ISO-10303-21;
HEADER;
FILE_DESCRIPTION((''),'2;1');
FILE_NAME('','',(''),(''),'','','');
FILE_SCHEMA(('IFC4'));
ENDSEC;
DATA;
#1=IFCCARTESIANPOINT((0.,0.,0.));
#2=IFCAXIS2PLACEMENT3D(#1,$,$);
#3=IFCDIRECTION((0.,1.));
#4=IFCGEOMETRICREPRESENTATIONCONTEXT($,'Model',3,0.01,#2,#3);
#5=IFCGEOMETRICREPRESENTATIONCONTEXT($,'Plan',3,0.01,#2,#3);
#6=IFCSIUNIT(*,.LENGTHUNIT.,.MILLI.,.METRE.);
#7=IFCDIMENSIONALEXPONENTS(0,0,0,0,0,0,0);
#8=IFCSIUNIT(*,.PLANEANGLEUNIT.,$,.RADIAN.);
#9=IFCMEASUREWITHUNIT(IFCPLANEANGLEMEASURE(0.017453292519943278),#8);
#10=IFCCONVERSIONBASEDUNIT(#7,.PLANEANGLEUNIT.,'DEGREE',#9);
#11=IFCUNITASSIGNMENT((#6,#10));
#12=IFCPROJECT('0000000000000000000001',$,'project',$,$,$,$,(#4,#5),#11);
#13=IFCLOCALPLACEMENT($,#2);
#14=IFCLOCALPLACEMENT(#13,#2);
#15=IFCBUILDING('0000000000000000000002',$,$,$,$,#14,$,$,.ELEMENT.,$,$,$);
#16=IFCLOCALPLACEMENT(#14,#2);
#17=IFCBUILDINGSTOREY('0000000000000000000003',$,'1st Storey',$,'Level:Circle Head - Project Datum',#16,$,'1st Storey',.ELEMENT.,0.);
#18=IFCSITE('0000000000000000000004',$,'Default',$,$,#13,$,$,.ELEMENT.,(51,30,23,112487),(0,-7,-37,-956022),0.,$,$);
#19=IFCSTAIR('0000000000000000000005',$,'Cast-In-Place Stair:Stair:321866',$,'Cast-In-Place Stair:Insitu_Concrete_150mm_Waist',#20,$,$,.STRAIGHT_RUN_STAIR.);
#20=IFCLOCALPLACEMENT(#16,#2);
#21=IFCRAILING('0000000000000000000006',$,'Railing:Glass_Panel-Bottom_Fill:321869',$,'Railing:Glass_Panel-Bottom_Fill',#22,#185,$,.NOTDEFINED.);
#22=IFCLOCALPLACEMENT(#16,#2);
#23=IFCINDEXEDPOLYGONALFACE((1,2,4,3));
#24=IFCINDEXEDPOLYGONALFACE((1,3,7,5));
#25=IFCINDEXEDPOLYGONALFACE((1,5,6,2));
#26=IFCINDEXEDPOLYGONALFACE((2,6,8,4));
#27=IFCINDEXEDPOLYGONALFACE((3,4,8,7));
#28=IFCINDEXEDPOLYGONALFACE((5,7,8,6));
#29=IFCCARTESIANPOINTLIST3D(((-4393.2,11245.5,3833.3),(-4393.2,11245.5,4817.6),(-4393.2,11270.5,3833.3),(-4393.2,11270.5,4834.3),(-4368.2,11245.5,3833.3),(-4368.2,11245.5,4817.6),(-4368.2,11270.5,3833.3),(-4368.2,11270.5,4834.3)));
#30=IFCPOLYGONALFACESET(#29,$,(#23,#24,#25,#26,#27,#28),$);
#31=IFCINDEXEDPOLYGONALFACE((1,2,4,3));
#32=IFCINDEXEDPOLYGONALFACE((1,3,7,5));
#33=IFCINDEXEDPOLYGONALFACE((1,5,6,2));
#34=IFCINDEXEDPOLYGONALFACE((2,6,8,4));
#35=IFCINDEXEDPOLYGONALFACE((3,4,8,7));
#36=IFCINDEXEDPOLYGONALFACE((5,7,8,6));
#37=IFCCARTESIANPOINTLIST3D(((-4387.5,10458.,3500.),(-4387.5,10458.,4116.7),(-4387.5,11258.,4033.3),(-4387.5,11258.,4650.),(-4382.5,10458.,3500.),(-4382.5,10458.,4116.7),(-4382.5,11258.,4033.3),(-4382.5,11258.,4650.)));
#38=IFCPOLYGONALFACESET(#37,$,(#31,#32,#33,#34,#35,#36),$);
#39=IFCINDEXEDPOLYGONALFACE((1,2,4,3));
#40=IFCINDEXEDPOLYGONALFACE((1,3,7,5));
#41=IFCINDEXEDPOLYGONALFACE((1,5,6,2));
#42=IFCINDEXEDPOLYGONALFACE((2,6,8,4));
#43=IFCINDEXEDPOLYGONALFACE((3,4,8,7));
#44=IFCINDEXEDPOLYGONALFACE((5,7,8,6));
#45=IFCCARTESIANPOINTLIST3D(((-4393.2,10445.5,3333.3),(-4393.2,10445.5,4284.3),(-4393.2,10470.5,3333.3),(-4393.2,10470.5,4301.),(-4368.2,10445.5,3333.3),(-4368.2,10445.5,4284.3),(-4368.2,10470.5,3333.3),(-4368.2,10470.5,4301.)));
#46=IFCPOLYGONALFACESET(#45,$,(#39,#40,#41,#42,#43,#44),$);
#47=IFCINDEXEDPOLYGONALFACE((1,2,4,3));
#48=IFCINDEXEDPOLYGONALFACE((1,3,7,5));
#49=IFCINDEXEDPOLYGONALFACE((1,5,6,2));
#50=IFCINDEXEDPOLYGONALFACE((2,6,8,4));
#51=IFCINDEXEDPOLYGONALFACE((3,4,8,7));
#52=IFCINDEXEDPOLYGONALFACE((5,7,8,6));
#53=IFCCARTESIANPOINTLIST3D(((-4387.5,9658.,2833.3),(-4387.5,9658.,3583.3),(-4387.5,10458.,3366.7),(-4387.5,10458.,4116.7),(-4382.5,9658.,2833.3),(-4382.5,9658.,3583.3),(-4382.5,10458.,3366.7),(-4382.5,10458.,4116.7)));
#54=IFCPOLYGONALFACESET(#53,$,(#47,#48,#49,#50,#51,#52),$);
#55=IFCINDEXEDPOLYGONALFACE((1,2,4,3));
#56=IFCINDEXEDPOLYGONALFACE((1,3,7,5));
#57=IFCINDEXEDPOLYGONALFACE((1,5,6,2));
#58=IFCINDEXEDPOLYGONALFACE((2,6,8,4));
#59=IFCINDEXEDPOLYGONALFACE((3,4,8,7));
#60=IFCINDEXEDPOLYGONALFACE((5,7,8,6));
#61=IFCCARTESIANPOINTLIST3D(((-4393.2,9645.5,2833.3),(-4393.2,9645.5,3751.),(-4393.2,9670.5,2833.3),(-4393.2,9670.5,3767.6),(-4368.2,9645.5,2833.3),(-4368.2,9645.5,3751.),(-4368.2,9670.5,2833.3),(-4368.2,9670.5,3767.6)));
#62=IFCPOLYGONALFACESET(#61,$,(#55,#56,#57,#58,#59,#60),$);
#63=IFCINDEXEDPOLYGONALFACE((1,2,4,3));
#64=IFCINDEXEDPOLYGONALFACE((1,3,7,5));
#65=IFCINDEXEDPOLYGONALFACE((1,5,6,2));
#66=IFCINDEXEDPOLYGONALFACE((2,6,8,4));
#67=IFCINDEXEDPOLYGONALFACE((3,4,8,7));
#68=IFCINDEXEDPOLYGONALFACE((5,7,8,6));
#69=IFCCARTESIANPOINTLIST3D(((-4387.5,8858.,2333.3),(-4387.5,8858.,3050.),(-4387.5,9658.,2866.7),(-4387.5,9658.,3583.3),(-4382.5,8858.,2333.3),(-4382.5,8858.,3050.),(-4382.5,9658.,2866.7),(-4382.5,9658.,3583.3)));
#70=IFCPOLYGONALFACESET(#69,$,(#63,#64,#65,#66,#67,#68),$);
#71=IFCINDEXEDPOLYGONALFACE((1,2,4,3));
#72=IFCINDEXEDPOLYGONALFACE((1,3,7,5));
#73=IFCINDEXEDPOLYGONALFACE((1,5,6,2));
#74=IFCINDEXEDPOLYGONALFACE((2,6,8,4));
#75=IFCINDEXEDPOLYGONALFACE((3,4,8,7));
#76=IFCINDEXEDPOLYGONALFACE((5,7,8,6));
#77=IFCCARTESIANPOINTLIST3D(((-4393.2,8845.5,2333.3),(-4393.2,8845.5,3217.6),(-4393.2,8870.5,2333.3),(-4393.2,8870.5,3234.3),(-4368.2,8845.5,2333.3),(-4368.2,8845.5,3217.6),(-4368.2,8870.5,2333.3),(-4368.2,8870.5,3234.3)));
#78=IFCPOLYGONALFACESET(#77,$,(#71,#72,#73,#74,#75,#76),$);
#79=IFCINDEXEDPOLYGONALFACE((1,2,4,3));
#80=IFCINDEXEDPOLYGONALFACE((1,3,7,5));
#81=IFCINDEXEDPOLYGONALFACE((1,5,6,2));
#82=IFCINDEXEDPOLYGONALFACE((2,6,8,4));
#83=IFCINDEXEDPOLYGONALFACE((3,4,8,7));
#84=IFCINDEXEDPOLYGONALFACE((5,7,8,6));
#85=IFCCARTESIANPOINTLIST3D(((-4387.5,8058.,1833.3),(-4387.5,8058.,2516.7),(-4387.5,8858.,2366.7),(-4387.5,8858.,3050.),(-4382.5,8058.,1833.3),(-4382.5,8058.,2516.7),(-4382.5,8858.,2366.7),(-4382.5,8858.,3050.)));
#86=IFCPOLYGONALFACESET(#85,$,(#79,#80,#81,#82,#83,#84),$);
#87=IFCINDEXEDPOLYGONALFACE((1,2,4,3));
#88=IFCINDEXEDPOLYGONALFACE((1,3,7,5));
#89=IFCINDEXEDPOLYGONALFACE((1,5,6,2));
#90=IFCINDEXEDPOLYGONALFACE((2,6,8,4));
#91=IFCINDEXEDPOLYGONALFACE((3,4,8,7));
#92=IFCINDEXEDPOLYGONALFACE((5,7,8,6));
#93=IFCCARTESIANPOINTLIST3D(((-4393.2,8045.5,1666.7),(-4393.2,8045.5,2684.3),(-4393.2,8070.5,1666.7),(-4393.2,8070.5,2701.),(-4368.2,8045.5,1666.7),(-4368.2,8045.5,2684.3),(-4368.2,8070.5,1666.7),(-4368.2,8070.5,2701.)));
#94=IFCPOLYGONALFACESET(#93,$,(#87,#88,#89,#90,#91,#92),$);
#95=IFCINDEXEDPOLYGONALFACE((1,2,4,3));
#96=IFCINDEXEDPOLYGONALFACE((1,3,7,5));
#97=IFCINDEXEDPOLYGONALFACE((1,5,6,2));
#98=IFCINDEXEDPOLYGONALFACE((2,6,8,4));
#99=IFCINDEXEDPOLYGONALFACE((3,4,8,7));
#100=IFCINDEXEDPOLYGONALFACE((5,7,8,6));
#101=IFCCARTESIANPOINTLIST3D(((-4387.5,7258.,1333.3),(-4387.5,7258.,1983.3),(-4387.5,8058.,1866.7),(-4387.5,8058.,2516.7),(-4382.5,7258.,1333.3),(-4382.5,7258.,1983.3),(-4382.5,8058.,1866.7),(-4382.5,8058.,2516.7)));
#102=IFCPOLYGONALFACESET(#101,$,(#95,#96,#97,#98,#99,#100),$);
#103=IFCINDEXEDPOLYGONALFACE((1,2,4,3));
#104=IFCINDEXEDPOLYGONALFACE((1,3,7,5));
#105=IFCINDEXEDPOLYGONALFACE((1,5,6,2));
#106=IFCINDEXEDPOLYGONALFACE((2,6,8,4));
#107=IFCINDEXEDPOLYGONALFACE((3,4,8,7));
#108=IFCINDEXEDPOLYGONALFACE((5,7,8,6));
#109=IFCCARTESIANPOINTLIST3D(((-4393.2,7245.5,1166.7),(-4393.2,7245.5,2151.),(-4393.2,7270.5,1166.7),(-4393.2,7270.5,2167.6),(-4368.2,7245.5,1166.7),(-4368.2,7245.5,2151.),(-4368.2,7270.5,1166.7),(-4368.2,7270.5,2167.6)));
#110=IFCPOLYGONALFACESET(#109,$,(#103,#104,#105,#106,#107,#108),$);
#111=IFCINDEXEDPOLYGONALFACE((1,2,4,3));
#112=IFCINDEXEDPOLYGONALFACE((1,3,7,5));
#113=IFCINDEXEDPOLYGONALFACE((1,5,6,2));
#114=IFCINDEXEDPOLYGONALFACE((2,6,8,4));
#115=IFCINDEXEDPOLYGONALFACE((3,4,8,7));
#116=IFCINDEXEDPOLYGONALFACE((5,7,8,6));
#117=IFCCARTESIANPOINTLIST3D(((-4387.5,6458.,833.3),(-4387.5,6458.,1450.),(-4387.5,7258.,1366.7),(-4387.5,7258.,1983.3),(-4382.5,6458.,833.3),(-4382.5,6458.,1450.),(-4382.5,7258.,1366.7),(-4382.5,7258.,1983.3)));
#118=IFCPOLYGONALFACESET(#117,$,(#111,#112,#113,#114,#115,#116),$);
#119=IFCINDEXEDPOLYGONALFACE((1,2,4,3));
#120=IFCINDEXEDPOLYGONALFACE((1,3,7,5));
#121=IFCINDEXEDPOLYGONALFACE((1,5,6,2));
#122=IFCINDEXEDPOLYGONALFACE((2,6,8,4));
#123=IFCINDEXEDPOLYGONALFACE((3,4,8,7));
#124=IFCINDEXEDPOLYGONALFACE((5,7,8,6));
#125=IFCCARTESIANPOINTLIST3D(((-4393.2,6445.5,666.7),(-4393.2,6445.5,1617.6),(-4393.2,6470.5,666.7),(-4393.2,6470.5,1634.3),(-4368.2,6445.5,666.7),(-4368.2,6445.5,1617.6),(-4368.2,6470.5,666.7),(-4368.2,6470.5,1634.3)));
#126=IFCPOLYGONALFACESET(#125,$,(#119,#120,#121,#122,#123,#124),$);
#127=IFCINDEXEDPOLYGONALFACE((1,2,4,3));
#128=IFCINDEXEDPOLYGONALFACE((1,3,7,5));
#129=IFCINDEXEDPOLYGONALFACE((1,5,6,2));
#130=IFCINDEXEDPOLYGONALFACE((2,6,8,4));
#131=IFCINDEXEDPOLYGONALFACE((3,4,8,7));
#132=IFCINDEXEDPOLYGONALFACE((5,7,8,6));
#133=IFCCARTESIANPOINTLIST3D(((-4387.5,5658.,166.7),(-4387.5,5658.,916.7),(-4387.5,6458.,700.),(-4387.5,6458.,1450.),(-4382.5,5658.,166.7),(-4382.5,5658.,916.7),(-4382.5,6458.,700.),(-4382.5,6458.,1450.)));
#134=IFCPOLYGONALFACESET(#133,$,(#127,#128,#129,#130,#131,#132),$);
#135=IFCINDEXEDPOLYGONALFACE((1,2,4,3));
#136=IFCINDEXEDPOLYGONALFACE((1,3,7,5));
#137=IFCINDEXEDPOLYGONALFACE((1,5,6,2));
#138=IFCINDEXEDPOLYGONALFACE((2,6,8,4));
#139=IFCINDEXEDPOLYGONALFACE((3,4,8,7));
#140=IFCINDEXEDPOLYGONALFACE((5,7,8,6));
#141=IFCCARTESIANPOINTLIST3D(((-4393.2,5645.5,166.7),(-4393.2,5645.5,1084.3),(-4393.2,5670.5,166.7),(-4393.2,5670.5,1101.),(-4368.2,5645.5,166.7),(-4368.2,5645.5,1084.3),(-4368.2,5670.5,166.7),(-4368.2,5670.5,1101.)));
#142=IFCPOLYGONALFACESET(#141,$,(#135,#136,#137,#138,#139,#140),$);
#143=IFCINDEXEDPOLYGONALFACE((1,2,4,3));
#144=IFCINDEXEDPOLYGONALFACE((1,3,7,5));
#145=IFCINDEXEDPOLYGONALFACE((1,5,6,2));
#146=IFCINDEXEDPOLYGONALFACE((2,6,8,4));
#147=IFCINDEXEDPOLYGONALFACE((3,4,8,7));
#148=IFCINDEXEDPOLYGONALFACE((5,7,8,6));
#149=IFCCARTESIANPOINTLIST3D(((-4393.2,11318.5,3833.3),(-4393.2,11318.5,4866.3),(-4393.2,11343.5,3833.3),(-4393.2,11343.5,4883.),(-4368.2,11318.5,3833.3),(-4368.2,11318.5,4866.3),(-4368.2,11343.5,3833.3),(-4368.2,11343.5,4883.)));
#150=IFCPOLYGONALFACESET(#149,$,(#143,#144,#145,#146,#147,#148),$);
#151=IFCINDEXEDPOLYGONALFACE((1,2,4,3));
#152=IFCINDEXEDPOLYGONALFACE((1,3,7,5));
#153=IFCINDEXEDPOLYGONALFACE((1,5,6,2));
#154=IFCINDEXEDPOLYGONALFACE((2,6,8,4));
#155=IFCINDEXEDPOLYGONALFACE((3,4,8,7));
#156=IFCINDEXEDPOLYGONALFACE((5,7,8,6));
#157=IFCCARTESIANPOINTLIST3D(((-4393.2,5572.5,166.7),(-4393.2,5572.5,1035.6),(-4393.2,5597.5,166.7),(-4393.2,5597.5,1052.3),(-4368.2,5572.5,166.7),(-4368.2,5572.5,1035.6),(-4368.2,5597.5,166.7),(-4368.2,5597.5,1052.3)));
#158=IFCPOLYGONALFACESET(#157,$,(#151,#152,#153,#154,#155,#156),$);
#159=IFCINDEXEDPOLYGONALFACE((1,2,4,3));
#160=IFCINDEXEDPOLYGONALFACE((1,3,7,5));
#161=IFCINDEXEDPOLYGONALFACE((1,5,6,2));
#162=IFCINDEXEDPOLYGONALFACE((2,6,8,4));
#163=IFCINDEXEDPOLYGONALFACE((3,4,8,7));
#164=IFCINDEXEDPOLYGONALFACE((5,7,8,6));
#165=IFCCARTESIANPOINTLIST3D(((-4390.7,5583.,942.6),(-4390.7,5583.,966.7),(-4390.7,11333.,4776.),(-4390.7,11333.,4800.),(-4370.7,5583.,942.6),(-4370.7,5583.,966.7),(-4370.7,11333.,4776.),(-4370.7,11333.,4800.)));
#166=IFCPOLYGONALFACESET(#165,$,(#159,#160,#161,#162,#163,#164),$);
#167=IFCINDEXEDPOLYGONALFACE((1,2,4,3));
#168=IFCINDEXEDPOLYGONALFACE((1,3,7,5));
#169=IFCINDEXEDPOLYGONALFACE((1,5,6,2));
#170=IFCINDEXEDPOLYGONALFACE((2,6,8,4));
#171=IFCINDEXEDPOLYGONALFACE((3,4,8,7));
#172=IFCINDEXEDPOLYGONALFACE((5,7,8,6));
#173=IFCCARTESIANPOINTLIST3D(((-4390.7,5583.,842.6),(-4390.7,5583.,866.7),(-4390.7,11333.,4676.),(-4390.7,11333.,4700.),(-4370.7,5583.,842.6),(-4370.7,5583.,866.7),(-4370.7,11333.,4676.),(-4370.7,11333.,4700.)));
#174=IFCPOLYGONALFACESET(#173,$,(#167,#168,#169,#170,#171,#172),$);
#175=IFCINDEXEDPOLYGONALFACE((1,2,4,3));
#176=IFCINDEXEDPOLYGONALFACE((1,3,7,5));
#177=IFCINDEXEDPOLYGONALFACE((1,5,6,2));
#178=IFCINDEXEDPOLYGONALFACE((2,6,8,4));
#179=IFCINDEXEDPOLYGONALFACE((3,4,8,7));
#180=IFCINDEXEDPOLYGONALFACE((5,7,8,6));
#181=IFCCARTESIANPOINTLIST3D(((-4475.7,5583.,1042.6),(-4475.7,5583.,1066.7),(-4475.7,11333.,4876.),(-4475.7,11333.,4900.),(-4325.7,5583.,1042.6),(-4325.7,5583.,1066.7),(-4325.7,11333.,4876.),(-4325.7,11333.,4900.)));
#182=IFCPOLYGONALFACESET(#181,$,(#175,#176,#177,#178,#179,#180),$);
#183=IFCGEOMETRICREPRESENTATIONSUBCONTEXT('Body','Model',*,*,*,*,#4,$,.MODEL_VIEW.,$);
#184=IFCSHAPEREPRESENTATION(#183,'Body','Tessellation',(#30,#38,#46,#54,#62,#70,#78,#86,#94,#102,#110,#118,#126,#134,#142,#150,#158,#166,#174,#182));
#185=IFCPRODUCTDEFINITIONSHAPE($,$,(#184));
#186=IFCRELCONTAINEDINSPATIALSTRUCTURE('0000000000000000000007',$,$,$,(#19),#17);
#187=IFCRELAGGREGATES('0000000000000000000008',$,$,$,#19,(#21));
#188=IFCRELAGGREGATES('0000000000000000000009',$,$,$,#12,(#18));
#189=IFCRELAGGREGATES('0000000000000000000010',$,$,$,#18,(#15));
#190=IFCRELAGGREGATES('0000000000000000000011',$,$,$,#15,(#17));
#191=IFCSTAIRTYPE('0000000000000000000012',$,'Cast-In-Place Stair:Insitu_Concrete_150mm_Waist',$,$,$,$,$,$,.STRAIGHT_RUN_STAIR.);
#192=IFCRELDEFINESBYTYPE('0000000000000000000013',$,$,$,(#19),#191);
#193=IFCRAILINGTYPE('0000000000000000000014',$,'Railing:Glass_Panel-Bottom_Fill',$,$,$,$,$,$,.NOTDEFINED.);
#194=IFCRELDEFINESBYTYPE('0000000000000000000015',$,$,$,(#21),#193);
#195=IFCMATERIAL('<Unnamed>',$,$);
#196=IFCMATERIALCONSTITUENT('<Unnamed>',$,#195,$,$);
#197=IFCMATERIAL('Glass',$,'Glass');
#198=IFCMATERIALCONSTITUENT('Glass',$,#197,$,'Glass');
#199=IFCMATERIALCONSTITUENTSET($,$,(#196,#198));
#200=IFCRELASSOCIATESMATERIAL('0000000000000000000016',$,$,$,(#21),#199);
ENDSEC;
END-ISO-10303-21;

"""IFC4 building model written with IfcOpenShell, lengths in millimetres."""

from ifc_helpers import new_model, entity, si_unit, converted_unit, direction, frame, origin, place, context, subcontext, project, spatial, indexed_curve, outline, extrude, material, constituent, constituent_set, type_object, element, aggregate, save


model = new_model("IFC4")

# Units and contexts
model_context = context("Model", 3, precision=0.01, world=origin(), true_north=direction((0.0, 1.0)))
plan_context = context("Plan", 3, precision=0.01, world=origin(), true_north=direction((0.0, 1.0)))
body_context = subcontext(model_context, "Body", "Model", "MODEL_VIEW")
ifc_project = project(units=[si_unit("LENGTHUNIT", "METRE", prefix="MILLI"), converted_unit("PLANEANGLEUNIT", "DEGREE", entity("IfcPlaneAngleMeasure", 0.017453292519943278), si_unit("PLANEANGLEUNIT", "RADIAN"), dimensions=[0, 0, 0, 0, 0, 0, 0])], contexts=[model_context, plan_context])

# Site, building, storey
site_placement = place(None, origin())
site = spatial("IfcSite", under=ifc_project, at=site_placement, Name="Default", CompositionType="ELEMENT", RefLatitude=(51, 30, 23, 112487), RefLongitude=(0, -7, -37, -956022), RefElevation=0.0)
building_placement = place(site_placement, origin())
building = spatial("IfcBuilding", under=site, at=building_placement, CompositionType="ELEMENT")
storey_placement = place(building_placement, origin())
storey = spatial("IfcBuildingStorey", under=building, at=storey_placement, Name="1st Storey", ObjectType="Level:Circle Head - Project Datum", LongName="1st Storey", CompositionType="ELEMENT", Elevation=0.0)

# Shared definitions
ifc_material_1 = material(Name="<Unnamed>")

# Stair, railing
stair_type_1 = type_object("IfcStairType", Name="Cast-In-Place Stair:Insitu_Concrete_150mm_Waist", PredefinedType="STRAIGHT_RUN_STAIR")
ifc_material_2 = material(Name="Glass", Category="Glass")
railing_type = type_object("IfcRailingType", Name="Railing:Glass_Panel-Bottom_Fill", PredefinedType="NOTDEFINED")
stair_1_placement = place(storey_placement, origin())
stair_1 = element("IfcStair", 1, at=stair_1_placement, inside=storey, type_object=stair_type_1, Name="Cast-In-Place Stair:Stair:321866", ObjectType="Cast-In-Place Stair:Insitu_Concrete_150mm_Waist", PredefinedType="STRAIGHT_RUN_STAIR")
ifc_constituent_1 = constituent(ifc_material_1, Name="<Unnamed>")
ifc_constituent_2 = constituent(ifc_material_2, Name="Glass", Category="Glass")
ifc_constituent_set_1 = constituent_set(constituents=[ifc_constituent_1, ifc_constituent_2])
railing_1_placement = place(stair_1_placement, frame((-4475.7, 5572.5, 166.7)))
railing_1 = element("IfcRailing", 2, at=railing_1_placement, type_object=railing_type, material=ifc_constituent_set_1, Name="Railing:Glass_Panel-Bottom_Fill:321869", ObjectType="Railing:Glass_Panel-Bottom_Fill", PredefinedType="NOTDEFINED", context=body_context, shape_type="SweptSolid", body=[
    extrude(outline(indexed_curve([(-488.0, -12.5), (496.3, -12.5), (496.3, 12.5), (-504.6, 12.5), (-488.0, -12.5)], self_intersect=False)), frame((82.5, 5685.5, 4163.0), z_axis=(1.0, 0.0, 0.0), x_axis=(0.0, 0.0, -1.0)), (0.0, 0.0, 1.0), 25.0),
    extrude(outline(indexed_curve([(-41.7, -400.0), (575.0, -400.0), (41.7, 400.0), (-575.0, 400.0), (-41.7, -400.0)], self_intersect=False)), frame((88.3, 5285.5, 3908.3), z_axis=(1.0, 0.0, 0.0), x_axis=(0.0, 0.0, -1.0)), (0.0, 0.0, 1.0), 5.0),
    extrude(outline(indexed_curve([(-471.3, -12.5), (479.6, -12.5), (479.6, 12.5), (-488.0, 12.5), (-471.3, -12.5)], self_intersect=False)), frame((82.5, 4885.5, 3646.3), z_axis=(1.0, 0.0, 0.0), x_axis=(0.0, 0.0, -1.0)), (0.0, 0.0, 1.0), 25.0),
    extrude(outline(indexed_curve([(-108.3, -400.0), (641.7, -400.0), (108.3, 400.0), (-641.7, 400.0), (-108.3, -400.0)], self_intersect=False)), frame((88.3, 4485.5, 3308.3), z_axis=(1.0, 0.0, 0.0), x_axis=(0.0, 0.0, -1.0)), (0.0, 0.0, 1.0), 5.0),
    extrude(outline(indexed_curve([(-454.6, -12.5), (463.0, -12.5), (463.0, 12.5), (-471.3, 12.5), (-454.6, -12.5)], self_intersect=False)), frame((82.5, 4085.5, 3129.6), z_axis=(1.0, 0.0, 0.0), x_axis=(0.0, 0.0, -1.0)), (0.0, 0.0, 1.0), 25.0),
    extrude(outline(indexed_curve([(-91.7, -400.0), (625.0, -400.0), (91.7, 400.0), (-625.0, 400.0), (-91.7, -400.0)], self_intersect=False)), frame((88.3, 3685.5, 2791.7), z_axis=(1.0, 0.0, 0.0), x_axis=(0.0, 0.0, -1.0)), (0.0, 0.0, 1.0), 5.0),
    extrude(outline(indexed_curve([(-438.0, -12.5), (446.3, -12.5), (446.3, 12.5), (-454.6, 12.5), (-438.0, -12.5)], self_intersect=False)), frame((82.5, 3285.5, 2613.0), z_axis=(1.0, 0.0, 0.0), x_axis=(0.0, 0.0, -1.0)), (0.0, 0.0, 1.0), 25.0),
    extrude(outline(indexed_curve([(-75.0, -400.0), (608.3, -400.0), (75.0, 400.0), (-608.3, 400.0), (-75.0, -400.0)], self_intersect=False)), frame((88.3, 2885.5, 2275.0), z_axis=(1.0, 0.0, 0.0), x_axis=(0.0, 0.0, -1.0)), (0.0, 0.0, 1.0), 5.0),
    extrude(outline(indexed_curve([(-504.6, -12.5), (513.0, -12.5), (513.0, 12.5), (-521.3, 12.5), (-504.6, -12.5)], self_intersect=False)), frame((82.5, 2485.5, 2013.0), z_axis=(1.0, 0.0, 0.0), x_axis=(0.0, 0.0, -1.0)), (0.0, 0.0, 1.0), 25.0),
    extrude(outline(indexed_curve([(-58.3, -400.0), (591.7, -400.0), (58.3, 400.0), (-591.7, 400.0), (-58.3, -400.0)], self_intersect=False)), frame((88.3, 2085.5, 1758.3), z_axis=(1.0, 0.0, 0.0), x_axis=(0.0, 0.0, -1.0)), (0.0, 0.0, 1.0), 5.0),
    extrude(outline(indexed_curve([(-488.0, -12.5), (496.3, -12.5), (496.3, 12.5), (-504.6, 12.5), (-488.0, -12.5)], self_intersect=False)), frame((82.5, 1685.5, 1496.3), z_axis=(1.0, 0.0, 0.0), x_axis=(0.0, 0.0, -1.0)), (0.0, 0.0, 1.0), 25.0),
    extrude(outline(indexed_curve([(-41.7, -400.0), (575.0, -400.0), (41.7, 400.0), (-575.0, 400.0), (-41.7, -400.0)], self_intersect=False)), frame((88.3, 1285.5, 1241.7), z_axis=(1.0, 0.0, 0.0), x_axis=(0.0, 0.0, -1.0)), (0.0, 0.0, 1.0), 5.0),
    extrude(outline(indexed_curve([(-471.3, -12.5), (479.6, -12.5), (479.6, 12.5), (-488.0, 12.5), (-471.3, -12.5)], self_intersect=False)), frame((82.5, 885.5, 979.6), z_axis=(1.0, 0.0, 0.0), x_axis=(0.0, 0.0, -1.0)), (0.0, 0.0, 1.0), 25.0),
    extrude(outline(indexed_curve([(-108.3, -400.0), (641.7, -400.0), (108.3, 400.0), (-641.7, 400.0), (-108.3, -400.0)], self_intersect=False)), frame((88.3, 485.5, 641.7), z_axis=(1.0, 0.0, 0.0), x_axis=(0.0, 0.0, -1.0)), (0.0, 0.0, 1.0), 5.0),
    extrude(outline(indexed_curve([(-454.6, -12.5), (463.0, -12.5), (463.0, 12.5), (-471.3, 12.5), (-454.6, -12.5)], self_intersect=False)), frame((82.5, 85.5, 463.0), z_axis=(1.0, 0.0, 0.0), x_axis=(0.0, 0.0, -1.0)), (0.0, 0.0, 1.0), 25.0),
    extrude(outline(indexed_curve([(-512.3, -12.5), (520.6, -12.5), (520.6, 12.5), (-529.0, 12.5), (-512.3, -12.5)], self_intersect=False)), frame((82.5, 5758.5, 4187.3), z_axis=(1.0, 0.0, 0.0), x_axis=(0.0, 0.0, -1.0)), (0.0, 0.0, 1.0), 25.0),
    extrude(outline(indexed_curve([(-430.3, -12.5), (438.6, -12.5), (438.6, 12.5), (-447.0, 12.5), (-430.3, -12.5)], self_intersect=False)), frame((82.5, 12.5, 438.6), z_axis=(1.0, 0.0, 0.0), x_axis=(0.0, 0.0, -1.0)), (0.0, 0.0, 1.0), 25.0),
    extrude(outline(indexed_curve([(-3462.0, -10.0), (3448.7, -10.0), (3462.0, 10.0), (-3448.7, 10.0), (-3462.0, -10.0)], self_intersect=False)), frame((85.0, 2885.5, 2704.6), z_axis=(1.0, 0.0, 0.0), x_axis=(0.0, 0.83205, 0.5547)), (0.0, 0.0, 1.0), 20.0),
    extrude(outline(indexed_curve([(-3462.0, -10.0), (3448.7, -10.0), (3462.0, 10.0), (-3448.7, 10.0), (-3462.0, -10.0)], self_intersect=False)), frame((85.0, 2885.5, 2604.6), z_axis=(1.0, 0.0, 0.0), x_axis=(0.0, 0.83205, 0.5547)), (0.0, 0.0, 1.0), 20.0),
    extrude(outline(indexed_curve([(-3462.0, -10.0), (3448.7, -10.0), (3462.0, 10.0), (-3448.7, 10.0), (-3462.0, -10.0)], self_intersect=False)), frame((0.0, 2885.5, 2804.6), z_axis=(1.0, 0.0, 0.0), x_axis=(0.0, 0.83205, 0.5547)), (0.0, 0.0, 1.0), 150.0),
])
aggregate(stair_1, [railing_1])

save(model, "model.ifc")
